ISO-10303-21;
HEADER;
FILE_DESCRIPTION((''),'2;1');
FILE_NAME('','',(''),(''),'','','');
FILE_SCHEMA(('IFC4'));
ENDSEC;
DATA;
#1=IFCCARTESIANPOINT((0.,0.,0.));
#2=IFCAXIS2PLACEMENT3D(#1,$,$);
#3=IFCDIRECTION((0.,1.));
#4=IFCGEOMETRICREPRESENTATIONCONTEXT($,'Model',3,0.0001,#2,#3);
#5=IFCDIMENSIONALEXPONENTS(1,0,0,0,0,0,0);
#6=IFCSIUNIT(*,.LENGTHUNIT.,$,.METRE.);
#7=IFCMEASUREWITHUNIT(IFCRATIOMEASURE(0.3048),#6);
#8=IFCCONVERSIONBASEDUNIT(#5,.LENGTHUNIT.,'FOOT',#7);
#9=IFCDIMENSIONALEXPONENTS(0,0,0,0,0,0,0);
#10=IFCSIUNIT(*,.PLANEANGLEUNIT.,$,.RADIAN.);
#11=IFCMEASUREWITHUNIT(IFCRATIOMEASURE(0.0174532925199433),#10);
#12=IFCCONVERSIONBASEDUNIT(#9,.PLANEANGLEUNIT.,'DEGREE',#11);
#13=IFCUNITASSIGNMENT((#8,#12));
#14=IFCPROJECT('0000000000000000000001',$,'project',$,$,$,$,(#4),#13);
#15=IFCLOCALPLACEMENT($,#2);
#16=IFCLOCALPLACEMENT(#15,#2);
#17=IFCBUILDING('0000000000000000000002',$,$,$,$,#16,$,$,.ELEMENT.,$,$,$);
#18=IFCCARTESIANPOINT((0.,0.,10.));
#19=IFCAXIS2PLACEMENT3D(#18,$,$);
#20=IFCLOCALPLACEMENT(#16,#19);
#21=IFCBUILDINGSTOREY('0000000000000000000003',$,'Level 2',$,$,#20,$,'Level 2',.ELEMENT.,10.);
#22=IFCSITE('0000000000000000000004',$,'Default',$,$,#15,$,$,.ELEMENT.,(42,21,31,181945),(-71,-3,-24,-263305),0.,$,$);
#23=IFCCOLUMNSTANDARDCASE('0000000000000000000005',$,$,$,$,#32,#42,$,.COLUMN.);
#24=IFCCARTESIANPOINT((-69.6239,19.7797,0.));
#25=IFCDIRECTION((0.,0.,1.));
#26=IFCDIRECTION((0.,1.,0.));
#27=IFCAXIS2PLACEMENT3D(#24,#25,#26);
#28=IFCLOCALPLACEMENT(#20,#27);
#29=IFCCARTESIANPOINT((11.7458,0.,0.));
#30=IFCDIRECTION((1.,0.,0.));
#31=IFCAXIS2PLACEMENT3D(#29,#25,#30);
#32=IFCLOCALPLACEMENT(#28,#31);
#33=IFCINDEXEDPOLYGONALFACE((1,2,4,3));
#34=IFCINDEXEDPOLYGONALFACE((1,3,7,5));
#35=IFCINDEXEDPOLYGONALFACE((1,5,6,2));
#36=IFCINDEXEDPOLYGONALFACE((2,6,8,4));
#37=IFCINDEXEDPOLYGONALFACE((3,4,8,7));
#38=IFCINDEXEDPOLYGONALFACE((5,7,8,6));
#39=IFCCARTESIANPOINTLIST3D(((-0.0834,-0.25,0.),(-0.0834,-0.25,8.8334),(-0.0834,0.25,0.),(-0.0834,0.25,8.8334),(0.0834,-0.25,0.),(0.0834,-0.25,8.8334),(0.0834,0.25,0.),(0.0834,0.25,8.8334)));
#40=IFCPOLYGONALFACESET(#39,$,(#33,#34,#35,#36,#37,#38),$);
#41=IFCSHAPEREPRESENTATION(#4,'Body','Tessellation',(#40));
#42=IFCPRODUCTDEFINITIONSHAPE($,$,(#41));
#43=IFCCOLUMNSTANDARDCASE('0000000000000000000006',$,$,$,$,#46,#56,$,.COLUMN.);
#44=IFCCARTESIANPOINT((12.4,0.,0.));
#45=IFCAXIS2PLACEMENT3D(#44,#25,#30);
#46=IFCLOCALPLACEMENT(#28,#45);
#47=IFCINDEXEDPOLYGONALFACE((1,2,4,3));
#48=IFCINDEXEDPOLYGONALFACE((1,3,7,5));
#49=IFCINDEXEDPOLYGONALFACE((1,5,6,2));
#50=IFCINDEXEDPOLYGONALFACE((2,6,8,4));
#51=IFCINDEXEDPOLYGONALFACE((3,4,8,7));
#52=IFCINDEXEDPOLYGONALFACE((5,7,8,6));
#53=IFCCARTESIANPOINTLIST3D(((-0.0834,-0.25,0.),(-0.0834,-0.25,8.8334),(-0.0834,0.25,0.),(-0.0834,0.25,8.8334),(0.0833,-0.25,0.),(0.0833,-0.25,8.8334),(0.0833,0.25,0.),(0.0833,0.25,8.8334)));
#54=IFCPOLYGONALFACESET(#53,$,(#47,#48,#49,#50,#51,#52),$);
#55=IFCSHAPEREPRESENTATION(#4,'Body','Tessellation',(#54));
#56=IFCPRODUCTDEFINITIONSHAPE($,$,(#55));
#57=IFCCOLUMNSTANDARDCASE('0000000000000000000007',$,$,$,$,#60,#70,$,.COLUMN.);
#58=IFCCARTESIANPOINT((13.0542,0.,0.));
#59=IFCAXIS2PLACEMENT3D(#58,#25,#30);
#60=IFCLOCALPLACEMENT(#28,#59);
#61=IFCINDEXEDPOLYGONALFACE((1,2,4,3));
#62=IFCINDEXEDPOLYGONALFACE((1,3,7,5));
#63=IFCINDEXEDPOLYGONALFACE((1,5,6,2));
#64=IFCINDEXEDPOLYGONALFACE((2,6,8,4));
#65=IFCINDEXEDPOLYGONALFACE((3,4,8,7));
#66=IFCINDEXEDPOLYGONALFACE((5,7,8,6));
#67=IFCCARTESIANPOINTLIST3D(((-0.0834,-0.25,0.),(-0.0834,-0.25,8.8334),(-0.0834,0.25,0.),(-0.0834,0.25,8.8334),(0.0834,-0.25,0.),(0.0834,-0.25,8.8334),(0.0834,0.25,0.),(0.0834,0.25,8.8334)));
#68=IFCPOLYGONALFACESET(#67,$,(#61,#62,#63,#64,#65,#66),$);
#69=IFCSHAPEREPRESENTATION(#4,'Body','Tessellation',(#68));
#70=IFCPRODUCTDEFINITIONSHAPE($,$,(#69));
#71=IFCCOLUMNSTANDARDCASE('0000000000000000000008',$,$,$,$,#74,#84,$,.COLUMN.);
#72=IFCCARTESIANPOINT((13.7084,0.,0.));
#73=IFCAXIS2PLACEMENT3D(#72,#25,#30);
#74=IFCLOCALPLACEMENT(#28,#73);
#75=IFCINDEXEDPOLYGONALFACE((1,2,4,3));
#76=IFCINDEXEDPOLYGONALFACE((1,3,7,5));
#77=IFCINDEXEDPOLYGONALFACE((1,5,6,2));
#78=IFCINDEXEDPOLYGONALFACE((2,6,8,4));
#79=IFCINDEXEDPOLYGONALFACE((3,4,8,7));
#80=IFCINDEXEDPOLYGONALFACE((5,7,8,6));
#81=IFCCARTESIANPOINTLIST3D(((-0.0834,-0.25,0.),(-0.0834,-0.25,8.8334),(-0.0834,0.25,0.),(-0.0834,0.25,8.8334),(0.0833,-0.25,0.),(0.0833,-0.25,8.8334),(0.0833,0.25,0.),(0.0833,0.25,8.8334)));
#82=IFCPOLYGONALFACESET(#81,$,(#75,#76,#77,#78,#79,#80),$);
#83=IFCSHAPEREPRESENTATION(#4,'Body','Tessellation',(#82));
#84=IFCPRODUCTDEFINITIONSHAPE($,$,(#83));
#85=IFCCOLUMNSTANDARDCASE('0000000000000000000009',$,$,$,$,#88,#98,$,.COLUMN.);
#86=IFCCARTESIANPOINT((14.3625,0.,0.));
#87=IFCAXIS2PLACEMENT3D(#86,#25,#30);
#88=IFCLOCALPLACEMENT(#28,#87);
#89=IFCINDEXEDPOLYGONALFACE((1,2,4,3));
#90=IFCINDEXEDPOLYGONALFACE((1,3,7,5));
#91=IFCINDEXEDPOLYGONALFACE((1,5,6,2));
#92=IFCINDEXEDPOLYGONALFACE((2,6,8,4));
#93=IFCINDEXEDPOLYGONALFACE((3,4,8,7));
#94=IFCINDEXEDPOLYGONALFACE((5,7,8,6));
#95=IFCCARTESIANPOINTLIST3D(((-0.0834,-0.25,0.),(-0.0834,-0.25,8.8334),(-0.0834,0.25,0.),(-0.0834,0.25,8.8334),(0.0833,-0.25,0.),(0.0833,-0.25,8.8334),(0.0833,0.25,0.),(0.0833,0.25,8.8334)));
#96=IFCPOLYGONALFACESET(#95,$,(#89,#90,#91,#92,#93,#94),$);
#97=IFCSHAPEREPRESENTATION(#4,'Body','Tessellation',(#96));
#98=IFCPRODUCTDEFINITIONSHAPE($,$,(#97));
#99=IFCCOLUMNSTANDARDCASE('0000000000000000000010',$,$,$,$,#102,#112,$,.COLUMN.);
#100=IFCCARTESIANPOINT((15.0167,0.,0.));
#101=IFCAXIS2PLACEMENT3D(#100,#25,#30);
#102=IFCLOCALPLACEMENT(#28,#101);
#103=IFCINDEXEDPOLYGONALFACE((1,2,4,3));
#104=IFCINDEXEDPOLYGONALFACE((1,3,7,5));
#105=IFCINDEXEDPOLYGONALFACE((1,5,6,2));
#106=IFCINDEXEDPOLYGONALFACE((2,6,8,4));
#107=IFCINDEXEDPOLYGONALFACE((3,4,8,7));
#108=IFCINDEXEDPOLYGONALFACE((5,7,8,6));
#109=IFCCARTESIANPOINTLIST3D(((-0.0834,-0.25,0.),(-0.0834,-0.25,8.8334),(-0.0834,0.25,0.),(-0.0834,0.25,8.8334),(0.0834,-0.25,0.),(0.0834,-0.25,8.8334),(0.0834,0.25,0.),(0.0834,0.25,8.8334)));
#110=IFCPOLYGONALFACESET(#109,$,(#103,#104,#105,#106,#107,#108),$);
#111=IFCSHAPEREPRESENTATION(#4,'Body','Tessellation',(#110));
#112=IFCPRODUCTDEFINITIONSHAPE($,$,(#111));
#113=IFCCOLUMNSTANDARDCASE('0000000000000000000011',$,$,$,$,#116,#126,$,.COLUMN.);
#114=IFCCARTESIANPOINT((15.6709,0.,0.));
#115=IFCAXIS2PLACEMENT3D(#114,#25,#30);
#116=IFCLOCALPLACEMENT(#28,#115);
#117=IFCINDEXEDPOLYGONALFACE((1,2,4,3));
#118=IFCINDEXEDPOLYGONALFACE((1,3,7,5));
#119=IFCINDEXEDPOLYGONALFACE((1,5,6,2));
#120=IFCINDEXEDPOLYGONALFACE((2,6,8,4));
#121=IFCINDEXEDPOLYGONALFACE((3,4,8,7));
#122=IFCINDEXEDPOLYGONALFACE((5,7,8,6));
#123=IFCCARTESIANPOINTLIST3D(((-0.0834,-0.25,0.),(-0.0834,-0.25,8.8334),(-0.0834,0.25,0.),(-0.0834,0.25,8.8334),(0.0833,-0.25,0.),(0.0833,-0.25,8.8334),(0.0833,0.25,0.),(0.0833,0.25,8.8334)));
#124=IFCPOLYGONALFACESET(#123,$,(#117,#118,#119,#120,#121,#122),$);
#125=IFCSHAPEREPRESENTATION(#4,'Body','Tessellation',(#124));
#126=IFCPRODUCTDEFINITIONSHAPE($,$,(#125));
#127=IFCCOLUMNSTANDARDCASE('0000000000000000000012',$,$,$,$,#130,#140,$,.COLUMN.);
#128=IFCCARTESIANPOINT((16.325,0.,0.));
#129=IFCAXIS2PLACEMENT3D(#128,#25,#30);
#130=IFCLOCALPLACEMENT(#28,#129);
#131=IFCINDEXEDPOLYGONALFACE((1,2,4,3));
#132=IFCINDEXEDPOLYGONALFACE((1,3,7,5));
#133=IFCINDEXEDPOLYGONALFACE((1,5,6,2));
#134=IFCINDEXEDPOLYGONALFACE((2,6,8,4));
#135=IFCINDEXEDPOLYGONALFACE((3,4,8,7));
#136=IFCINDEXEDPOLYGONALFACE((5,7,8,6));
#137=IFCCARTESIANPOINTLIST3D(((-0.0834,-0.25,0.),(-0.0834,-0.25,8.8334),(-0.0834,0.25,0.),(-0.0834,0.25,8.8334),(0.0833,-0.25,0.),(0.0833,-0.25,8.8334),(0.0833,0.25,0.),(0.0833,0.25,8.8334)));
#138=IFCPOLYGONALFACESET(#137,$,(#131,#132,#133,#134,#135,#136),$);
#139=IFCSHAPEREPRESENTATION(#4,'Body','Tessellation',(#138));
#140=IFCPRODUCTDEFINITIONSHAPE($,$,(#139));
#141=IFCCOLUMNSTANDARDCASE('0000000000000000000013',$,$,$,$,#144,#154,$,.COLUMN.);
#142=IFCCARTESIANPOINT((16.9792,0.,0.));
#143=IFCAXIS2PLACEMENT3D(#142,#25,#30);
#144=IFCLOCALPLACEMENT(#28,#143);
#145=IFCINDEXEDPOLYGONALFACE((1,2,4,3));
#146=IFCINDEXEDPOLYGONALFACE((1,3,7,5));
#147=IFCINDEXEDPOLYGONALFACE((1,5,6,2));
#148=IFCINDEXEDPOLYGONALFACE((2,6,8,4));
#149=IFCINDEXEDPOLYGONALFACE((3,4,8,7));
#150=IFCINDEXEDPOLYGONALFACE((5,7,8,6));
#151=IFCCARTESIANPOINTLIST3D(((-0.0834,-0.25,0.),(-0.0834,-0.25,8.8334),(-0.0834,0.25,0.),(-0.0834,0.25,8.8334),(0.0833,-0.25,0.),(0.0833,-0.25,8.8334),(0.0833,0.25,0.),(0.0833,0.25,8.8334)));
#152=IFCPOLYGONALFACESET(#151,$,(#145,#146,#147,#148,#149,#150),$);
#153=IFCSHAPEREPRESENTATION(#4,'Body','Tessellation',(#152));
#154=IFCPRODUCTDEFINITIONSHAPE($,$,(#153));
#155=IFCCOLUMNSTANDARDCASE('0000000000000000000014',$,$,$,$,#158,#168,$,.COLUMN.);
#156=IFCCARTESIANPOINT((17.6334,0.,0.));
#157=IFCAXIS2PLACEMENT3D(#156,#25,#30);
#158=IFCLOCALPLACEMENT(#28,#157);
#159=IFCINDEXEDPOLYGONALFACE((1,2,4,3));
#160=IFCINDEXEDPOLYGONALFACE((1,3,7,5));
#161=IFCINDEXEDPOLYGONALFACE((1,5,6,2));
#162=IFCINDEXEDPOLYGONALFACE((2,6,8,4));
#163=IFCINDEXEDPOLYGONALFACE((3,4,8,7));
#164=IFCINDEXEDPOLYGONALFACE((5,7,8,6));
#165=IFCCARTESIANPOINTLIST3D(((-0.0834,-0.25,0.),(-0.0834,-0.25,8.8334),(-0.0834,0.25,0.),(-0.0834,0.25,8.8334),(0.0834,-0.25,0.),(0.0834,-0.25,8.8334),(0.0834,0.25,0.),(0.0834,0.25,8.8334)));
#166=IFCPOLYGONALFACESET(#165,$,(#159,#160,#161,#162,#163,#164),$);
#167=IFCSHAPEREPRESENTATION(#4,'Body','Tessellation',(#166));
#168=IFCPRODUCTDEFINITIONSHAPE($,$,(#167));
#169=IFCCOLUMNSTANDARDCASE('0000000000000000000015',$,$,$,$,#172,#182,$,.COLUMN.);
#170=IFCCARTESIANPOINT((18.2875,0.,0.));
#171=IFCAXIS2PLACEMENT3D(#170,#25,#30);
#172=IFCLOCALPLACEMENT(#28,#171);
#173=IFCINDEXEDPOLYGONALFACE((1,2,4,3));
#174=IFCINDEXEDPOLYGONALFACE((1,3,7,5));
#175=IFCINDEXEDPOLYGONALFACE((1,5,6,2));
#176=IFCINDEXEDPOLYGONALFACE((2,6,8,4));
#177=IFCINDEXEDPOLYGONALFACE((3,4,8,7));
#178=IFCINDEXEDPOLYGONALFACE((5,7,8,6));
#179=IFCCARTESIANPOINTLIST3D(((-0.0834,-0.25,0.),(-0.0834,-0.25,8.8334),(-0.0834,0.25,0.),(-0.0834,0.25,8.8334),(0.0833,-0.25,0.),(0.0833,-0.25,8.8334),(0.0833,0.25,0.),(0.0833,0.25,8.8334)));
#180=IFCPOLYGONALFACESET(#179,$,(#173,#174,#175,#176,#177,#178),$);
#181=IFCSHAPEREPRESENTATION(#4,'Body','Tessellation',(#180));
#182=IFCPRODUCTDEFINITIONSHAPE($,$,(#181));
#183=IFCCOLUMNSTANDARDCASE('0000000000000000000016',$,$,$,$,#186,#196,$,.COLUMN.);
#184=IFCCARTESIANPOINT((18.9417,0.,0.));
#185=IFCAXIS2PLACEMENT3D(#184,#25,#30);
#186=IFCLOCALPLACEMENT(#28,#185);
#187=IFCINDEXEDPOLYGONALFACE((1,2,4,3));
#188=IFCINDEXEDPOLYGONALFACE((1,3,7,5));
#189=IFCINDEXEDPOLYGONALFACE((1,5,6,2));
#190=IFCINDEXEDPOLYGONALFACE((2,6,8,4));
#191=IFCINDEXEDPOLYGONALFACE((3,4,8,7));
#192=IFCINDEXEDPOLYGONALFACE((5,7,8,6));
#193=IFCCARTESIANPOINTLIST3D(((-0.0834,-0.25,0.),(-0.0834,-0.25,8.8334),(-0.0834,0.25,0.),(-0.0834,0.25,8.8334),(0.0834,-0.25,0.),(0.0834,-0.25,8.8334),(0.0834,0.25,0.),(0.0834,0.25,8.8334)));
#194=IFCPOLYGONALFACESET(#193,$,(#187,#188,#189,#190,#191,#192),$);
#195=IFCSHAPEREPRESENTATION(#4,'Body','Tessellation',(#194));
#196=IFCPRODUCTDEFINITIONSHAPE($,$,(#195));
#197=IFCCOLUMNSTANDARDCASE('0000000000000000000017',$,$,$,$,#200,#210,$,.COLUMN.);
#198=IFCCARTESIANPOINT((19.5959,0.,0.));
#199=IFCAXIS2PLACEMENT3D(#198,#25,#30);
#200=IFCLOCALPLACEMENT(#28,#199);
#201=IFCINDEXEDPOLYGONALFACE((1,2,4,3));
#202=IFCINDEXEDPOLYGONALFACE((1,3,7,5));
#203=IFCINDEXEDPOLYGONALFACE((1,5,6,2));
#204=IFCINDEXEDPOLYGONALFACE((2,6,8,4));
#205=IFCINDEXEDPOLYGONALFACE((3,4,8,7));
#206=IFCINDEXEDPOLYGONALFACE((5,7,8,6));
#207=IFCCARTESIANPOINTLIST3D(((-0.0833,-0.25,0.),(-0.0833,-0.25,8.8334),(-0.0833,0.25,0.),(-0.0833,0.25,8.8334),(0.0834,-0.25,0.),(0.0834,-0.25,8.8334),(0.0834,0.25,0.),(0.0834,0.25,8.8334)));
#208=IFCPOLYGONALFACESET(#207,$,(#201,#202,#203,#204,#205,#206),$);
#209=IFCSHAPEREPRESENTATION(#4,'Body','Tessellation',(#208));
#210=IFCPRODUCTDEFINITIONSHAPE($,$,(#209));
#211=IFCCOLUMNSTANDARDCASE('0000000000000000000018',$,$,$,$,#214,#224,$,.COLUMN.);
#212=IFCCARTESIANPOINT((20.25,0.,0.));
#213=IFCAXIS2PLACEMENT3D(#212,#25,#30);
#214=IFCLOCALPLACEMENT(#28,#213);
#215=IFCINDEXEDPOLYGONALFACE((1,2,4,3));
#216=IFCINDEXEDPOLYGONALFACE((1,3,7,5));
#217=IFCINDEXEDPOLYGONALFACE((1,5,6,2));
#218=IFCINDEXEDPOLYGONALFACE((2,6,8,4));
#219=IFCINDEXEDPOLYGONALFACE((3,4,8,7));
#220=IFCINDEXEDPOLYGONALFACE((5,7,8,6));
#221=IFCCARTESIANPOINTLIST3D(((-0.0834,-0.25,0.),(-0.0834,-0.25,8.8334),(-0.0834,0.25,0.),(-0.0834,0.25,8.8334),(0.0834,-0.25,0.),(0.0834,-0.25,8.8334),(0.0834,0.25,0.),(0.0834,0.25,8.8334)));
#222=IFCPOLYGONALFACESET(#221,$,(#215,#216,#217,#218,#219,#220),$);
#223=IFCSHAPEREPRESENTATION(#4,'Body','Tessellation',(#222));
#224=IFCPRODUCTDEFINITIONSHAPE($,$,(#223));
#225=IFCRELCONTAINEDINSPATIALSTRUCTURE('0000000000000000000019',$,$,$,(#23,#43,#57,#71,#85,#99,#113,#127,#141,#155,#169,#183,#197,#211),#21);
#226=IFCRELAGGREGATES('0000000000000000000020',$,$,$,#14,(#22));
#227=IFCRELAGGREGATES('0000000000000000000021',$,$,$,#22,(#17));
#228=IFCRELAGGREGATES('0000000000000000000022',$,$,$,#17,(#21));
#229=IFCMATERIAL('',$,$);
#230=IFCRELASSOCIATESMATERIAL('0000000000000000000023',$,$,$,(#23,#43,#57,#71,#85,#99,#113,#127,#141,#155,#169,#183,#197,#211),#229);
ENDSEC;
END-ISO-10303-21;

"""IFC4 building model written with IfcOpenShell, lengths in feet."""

from ifc_helpers import new_model, entity, si_unit, converted_unit, direction, frame, origin, place, context, project, spatial, rectangle, extrude, material, element, save


model = new_model("IFC4")

# Units and contexts
model_context = context("Model", 3, precision=0.0001, world=origin(), true_north=direction((0.0, 1.0)))
ifc_project = project(units=[converted_unit("LENGTHUNIT", "FOOT", entity("IfcRatioMeasure", 0.3048), si_unit("LENGTHUNIT", "METRE"), dimensions=[1, 0, 0, 0, 0, 0, 0]), converted_unit("PLANEANGLEUNIT", "DEGREE", entity("IfcRatioMeasure", 0.0174532925199433), si_unit("PLANEANGLEUNIT", "RADIAN"), dimensions=[0, 0, 0, 0, 0, 0, 0])], contexts=[model_context])

# Site, building, storey
site_placement = place(None, origin())
site = spatial("IfcSite", under=ifc_project, at=site_placement, Name="Default", CompositionType="ELEMENT", RefLatitude=(42, 21, 31, 181945), RefLongitude=(-71, -3, -24, -263305), RefElevation=0.0)
building_placement = place(site_placement, origin())
building = spatial("IfcBuilding", under=site, at=building_placement, CompositionType="ELEMENT")
storey_placement = place(building_placement, frame((0.0, 0.0, 10.0)))
storey = spatial("IfcBuildingStorey", under=building, at=storey_placement, Name="Level 2", LongName="Level 2", CompositionType="ELEMENT", Elevation=10.0)

# Columns
ifc_material_1 = material(Name="")
placement_1 = place(storey_placement, frame((-69.6239, 19.7797, 0.0), z_axis=(0.0, 0.0, 1.0), x_axis=(0.0, 1.0, 0.0)))
for number, where, z_axis, x_axis in (
    (1, (11.7458, 0.0, 0.0), (0.0, 0.0, 1.0), (1.0, 0.0, 0.0)),
    (2, (12.4, 0.0, 0.0), (0.0, 0.0, 1.0), (1.0, 0.0, 0.0)),
    (3, (13.0542, 0.0, 0.0), (0.0, 0.0, 1.0), (1.0, 0.0, 0.0)),
    (4, (13.7084, 0.0, 0.0), (0.0, 0.0, 1.0), (1.0, 0.0, 0.0)),
    (5, (14.3625, 0.0, 0.0), (0.0, 0.0, 1.0), (1.0, 0.0, 0.0)),
    (6, (15.0167, 0.0, 0.0), (0.0, 0.0, 1.0), (1.0, 0.0, 0.0)),
    (7, (15.6709, 0.0, 0.0), (0.0, 0.0, 1.0), (1.0, 0.0, 0.0)),
    (8, (16.325, 0.0, 0.0), (0.0, 0.0, 1.0), (1.0, 0.0, 0.0)),
    (9, (16.9792, 0.0, 0.0), (0.0, 0.0, 1.0), (1.0, 0.0, 0.0)),
    (10, (17.6334, 0.0, 0.0), (0.0, 0.0, 1.0), (1.0, 0.0, 0.0)),
    (11, (18.2875, 0.0, 0.0), (0.0, 0.0, 1.0), (1.0, 0.0, 0.0)),
    (12, (18.9417, 0.0, 0.0), (0.0, 0.0, 1.0), (1.0, 0.0, 0.0)),
    (13, (19.5959, 0.0, 0.0), (0.0, 0.0, 1.0), (1.0, 0.0, 0.0)),
    (14, (20.25, 0.0, 0.0), (0.0, 0.0, 1.0), (1.0, 0.0, 0.0)),
):
    element("IfcColumnStandardCase", number, at=place(placement_1, frame(where, z_axis=z_axis, x_axis=x_axis)), inside=storey, material=ifc_material_1, PredefinedType="COLUMN", context=model_context, shape_type="SweptSolid", body=[
        extrude(rectangle(XDim=0.1667, YDim=0.5), origin(), (0.0, 0.0, 1.0), 8.8334),
    ])

save(model, "model.ifc")
